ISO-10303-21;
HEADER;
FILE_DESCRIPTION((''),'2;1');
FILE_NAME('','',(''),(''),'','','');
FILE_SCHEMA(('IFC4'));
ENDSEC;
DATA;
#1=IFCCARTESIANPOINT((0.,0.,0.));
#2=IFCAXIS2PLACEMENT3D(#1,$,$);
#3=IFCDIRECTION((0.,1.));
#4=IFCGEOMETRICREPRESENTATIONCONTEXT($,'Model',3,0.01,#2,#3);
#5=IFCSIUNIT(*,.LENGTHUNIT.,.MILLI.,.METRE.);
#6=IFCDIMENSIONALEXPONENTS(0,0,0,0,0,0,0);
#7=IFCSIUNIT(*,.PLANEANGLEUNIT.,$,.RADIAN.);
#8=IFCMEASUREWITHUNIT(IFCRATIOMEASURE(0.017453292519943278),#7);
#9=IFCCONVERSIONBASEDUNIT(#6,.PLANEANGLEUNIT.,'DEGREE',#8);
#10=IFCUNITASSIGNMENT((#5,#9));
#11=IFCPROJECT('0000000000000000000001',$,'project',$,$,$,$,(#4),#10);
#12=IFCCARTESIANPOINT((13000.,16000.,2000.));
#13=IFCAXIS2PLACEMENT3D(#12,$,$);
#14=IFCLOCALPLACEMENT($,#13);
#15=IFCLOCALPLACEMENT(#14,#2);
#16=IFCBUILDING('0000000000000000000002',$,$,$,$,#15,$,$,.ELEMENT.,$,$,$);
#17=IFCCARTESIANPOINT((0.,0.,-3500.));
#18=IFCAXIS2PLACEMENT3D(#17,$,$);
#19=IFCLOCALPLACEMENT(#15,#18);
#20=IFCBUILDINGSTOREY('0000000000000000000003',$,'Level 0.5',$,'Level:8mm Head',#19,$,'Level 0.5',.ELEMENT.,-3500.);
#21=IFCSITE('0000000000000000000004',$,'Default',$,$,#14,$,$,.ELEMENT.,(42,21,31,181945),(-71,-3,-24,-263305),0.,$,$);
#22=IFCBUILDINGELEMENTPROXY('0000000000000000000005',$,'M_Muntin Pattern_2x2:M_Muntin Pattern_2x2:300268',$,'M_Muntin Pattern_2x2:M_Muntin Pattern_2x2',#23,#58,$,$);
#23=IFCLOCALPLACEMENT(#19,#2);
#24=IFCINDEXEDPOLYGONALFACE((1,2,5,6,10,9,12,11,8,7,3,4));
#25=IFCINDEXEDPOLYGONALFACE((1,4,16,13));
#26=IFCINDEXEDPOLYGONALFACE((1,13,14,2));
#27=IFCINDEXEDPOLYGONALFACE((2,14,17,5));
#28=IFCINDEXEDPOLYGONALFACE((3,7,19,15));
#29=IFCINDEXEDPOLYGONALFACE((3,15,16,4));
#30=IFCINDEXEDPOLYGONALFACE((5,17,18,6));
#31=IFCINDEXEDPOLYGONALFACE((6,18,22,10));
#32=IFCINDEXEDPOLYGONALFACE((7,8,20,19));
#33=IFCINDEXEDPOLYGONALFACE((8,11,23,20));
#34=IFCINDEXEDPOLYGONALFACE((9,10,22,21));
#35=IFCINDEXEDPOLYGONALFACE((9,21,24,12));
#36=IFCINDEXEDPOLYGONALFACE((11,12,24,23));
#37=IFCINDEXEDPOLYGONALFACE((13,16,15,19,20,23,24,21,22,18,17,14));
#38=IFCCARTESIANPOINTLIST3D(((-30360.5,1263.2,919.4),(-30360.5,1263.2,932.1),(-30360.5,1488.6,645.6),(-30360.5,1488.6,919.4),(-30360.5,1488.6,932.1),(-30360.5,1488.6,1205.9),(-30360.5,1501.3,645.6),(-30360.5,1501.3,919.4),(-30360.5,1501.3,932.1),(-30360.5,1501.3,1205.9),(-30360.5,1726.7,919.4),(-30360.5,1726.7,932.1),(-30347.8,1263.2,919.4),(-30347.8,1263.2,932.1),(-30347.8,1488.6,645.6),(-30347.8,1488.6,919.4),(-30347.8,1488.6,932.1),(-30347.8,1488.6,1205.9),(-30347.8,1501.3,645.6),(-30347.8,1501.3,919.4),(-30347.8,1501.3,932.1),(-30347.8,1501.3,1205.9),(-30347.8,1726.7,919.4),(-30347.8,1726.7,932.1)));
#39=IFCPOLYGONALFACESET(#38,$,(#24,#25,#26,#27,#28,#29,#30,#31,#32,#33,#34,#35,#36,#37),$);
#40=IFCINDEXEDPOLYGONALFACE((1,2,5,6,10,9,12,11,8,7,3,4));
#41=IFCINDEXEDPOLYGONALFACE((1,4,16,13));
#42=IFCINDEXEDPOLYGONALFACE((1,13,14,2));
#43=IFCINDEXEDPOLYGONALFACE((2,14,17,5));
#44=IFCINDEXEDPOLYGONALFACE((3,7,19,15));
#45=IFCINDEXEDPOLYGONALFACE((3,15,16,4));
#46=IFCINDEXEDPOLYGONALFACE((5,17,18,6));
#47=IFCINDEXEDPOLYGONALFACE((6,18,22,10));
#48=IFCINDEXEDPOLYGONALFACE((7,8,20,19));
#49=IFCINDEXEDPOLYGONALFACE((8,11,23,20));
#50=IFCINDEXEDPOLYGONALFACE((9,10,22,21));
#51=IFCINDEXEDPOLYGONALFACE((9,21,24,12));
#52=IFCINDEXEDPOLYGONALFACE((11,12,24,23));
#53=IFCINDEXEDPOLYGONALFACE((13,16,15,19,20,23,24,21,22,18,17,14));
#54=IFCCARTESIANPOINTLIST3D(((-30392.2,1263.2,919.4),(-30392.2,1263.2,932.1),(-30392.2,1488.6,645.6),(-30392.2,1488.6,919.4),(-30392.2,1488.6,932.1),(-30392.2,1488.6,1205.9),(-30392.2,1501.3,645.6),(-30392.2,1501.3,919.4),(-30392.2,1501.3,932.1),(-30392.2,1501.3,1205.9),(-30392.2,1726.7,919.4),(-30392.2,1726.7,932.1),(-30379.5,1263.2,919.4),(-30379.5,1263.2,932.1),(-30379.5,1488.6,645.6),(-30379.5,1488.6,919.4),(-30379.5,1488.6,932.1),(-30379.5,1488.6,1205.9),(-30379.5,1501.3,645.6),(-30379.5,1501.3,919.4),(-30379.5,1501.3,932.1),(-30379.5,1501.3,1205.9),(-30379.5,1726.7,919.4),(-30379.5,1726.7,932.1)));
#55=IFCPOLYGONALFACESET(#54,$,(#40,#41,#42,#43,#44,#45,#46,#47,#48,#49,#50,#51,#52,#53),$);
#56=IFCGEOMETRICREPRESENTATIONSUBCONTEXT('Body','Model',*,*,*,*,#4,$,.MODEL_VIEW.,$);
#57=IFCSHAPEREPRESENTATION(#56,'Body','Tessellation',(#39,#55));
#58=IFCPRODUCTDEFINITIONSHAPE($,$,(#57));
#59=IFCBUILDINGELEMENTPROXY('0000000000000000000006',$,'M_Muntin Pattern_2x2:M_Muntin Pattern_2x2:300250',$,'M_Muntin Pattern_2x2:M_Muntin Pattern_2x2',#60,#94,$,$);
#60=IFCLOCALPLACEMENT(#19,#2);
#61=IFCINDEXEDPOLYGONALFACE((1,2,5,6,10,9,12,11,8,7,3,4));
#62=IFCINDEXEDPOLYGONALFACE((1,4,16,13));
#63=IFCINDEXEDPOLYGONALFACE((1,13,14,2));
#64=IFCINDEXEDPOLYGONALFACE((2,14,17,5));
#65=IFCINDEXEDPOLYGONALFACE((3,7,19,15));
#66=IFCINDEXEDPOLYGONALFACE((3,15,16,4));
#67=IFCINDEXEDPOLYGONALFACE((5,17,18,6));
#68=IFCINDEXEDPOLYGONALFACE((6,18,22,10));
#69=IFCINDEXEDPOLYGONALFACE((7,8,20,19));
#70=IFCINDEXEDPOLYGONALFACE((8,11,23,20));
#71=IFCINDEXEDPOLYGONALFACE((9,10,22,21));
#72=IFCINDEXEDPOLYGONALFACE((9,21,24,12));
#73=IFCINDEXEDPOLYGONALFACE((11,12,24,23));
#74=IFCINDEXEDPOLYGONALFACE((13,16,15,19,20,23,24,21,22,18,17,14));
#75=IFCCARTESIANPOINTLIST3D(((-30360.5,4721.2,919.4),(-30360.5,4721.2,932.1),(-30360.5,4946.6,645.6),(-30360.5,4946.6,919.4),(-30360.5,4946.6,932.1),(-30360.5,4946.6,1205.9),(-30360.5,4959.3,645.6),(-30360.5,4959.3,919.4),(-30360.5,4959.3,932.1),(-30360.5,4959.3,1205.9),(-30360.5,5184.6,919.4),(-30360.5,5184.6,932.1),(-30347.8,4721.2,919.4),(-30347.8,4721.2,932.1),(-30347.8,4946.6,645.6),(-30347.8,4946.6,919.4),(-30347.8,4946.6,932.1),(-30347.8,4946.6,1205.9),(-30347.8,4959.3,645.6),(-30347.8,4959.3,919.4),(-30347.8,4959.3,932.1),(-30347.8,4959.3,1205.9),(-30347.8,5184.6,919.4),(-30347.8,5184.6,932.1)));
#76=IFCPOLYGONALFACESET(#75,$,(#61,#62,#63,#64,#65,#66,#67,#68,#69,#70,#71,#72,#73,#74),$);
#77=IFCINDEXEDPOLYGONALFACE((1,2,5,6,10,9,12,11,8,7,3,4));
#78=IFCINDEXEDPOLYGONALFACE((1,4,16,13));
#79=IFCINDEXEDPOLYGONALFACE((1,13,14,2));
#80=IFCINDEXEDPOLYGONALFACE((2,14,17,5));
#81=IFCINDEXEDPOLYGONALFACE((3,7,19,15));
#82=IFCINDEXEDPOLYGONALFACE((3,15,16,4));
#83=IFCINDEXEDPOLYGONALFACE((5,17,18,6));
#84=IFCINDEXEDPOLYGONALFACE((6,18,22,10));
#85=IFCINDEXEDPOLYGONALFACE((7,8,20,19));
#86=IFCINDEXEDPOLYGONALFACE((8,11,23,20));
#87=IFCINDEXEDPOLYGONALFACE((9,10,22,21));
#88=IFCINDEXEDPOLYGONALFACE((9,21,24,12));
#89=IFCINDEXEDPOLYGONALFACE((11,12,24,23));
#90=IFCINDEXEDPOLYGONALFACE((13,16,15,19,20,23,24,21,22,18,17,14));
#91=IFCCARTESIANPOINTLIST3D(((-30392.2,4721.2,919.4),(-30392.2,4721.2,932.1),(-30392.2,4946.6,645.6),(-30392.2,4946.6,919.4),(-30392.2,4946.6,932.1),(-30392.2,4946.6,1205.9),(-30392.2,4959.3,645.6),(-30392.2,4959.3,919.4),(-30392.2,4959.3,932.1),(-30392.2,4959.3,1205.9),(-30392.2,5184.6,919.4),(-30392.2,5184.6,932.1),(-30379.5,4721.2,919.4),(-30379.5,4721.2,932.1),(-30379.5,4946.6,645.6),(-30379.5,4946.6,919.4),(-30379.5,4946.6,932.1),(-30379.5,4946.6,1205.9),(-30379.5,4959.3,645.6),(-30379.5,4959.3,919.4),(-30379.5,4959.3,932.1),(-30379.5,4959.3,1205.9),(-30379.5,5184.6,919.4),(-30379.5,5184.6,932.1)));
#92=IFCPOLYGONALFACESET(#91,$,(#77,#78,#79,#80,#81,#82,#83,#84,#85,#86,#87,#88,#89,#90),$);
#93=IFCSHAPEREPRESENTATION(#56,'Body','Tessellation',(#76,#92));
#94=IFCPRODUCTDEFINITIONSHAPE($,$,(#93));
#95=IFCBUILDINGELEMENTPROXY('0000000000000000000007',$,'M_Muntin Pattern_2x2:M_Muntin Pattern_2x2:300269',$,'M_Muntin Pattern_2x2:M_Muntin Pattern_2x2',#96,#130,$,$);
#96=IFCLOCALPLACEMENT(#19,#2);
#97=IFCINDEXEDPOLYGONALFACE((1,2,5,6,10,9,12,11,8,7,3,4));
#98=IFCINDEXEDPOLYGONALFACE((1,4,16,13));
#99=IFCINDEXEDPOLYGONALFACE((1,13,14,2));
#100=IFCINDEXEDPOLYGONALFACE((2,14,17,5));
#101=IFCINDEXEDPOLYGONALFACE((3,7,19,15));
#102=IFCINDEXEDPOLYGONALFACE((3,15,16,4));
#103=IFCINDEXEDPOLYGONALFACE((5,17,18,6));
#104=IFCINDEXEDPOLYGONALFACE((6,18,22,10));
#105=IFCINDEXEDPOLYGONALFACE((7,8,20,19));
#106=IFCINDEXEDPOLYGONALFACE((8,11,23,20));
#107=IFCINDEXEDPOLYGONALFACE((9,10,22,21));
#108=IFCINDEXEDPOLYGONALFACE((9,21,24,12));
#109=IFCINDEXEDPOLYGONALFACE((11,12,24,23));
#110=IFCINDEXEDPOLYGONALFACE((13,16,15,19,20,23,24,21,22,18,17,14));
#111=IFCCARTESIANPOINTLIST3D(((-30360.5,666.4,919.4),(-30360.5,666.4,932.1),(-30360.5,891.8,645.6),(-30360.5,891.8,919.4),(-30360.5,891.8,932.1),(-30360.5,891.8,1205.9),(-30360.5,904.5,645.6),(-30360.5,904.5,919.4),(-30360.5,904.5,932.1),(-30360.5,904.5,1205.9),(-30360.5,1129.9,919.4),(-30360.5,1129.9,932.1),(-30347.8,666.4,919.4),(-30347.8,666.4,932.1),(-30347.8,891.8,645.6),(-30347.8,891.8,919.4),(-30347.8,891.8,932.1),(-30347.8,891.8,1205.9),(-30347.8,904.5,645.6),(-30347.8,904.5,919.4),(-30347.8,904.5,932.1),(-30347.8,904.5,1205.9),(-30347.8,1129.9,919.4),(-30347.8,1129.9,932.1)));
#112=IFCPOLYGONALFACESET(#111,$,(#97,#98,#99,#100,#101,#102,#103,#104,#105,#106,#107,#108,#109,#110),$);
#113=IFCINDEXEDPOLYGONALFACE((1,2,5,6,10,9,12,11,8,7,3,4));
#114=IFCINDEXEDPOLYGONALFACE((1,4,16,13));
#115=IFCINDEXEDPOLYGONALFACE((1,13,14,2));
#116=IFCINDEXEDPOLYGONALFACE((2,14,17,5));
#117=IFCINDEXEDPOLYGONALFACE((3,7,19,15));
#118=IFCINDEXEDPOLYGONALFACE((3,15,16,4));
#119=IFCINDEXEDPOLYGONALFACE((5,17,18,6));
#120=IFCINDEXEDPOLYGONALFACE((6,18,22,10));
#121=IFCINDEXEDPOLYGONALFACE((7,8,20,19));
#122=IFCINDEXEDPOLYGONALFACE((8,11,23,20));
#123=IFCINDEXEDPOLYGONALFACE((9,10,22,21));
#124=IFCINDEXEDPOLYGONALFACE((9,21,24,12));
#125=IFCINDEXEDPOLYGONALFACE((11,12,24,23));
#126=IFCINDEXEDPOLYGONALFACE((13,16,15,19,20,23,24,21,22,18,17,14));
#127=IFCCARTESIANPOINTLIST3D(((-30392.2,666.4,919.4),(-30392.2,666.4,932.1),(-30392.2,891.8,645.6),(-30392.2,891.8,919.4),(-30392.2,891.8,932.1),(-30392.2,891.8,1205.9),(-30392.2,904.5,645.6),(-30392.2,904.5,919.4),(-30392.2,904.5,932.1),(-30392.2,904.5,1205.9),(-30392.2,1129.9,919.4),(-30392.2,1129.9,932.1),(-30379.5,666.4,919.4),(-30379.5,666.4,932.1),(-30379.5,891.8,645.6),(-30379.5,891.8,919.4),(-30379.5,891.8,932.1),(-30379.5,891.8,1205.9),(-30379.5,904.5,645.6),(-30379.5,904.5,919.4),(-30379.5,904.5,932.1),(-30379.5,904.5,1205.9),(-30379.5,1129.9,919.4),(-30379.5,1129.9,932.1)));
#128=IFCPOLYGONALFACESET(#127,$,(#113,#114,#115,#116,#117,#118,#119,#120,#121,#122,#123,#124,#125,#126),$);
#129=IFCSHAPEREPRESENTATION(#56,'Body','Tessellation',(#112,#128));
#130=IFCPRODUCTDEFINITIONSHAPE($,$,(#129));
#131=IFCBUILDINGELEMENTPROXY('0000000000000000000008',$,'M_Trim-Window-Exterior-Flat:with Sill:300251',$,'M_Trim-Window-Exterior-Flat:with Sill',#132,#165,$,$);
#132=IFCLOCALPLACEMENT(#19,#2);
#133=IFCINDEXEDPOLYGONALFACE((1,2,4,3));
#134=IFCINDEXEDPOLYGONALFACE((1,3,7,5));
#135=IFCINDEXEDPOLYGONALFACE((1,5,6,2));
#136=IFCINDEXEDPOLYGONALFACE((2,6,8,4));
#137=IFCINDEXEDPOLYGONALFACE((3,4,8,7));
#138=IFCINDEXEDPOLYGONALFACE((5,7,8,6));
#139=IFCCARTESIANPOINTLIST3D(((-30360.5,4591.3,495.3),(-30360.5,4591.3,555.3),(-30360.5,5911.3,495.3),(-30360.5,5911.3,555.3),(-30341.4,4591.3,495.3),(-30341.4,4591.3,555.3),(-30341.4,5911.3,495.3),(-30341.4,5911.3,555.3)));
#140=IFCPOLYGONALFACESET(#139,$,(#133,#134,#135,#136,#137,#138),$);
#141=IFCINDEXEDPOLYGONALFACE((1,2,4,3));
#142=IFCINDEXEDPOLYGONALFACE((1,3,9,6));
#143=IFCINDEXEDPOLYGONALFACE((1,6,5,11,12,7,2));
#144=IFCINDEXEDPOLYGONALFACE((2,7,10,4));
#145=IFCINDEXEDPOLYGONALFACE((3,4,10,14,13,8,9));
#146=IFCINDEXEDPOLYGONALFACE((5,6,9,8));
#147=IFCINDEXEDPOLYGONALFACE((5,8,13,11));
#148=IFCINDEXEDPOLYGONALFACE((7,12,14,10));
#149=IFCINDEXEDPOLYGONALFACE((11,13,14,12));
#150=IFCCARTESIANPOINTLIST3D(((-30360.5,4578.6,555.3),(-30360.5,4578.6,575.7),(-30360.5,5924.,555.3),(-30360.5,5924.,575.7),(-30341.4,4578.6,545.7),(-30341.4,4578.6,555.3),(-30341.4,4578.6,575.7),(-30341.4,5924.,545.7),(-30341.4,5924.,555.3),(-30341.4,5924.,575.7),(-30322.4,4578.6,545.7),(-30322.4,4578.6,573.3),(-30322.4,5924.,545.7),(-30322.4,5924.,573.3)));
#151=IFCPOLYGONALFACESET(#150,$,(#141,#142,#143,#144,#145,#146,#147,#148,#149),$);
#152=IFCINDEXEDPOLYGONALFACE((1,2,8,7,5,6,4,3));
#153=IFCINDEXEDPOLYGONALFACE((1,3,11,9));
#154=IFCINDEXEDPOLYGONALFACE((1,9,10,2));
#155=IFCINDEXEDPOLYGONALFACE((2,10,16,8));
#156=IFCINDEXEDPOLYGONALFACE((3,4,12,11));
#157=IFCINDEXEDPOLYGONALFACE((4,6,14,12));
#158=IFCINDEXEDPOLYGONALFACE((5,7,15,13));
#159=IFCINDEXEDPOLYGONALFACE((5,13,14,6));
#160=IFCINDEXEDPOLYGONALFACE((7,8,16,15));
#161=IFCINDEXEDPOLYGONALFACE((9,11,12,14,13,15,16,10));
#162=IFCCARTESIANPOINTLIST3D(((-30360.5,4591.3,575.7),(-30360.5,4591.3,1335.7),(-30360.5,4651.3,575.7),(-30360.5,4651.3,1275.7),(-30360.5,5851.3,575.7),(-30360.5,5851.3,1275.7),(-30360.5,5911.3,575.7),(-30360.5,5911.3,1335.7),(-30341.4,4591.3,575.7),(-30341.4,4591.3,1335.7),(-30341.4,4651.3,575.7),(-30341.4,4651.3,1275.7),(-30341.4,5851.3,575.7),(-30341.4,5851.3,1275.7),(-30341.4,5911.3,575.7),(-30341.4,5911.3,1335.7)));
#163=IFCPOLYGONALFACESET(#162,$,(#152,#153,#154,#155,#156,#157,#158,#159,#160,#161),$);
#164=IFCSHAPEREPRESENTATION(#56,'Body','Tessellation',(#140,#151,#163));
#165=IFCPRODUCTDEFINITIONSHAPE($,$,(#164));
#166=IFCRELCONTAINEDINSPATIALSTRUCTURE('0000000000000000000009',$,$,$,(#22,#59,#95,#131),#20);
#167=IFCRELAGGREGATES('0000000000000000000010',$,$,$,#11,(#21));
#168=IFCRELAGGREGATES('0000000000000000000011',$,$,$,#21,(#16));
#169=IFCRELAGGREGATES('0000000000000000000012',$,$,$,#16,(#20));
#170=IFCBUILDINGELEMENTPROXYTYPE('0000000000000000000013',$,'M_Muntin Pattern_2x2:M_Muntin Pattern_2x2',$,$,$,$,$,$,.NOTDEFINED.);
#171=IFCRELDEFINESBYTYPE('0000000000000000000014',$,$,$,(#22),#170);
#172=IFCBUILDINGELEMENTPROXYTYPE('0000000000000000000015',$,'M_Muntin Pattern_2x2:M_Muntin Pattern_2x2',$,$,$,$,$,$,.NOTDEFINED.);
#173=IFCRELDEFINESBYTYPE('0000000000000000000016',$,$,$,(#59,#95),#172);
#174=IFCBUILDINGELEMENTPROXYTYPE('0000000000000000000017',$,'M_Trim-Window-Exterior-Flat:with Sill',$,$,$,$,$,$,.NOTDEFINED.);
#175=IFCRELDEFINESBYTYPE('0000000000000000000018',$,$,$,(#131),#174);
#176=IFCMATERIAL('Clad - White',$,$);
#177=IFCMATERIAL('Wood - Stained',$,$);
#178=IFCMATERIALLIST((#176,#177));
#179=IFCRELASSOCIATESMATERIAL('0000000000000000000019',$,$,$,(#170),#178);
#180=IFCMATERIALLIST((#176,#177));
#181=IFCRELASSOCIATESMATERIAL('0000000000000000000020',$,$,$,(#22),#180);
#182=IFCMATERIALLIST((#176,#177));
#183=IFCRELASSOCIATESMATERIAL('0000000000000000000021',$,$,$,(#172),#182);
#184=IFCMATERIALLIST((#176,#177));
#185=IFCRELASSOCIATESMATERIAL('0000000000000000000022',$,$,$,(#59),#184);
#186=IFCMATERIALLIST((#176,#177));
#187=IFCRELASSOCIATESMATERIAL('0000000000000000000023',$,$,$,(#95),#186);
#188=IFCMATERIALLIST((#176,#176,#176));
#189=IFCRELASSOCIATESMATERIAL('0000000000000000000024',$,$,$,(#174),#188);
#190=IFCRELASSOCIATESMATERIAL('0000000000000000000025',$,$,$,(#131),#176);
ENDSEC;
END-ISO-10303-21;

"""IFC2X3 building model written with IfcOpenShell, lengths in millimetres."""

from ifc_helpers import new_model, entity, si_unit, converted_unit, direction, frame, frame_2d, origin, place, context, subcontext, project, spatial, polyline, rectangle, outline, extrude, source, transform, mapped, material, material_list, type_object, type_shapes, element, save


model = new_model("IFC2X3")

# Units and contexts
model_context = context("Model", 3, precision=0.01, world=origin(), true_north=direction((0.0, 1.0)))
body_context = subcontext(model_context, "Body", "Model", "MODEL_VIEW")
ifc_project = project(units=[si_unit("LENGTHUNIT", "METRE", prefix="MILLI"), converted_unit("PLANEANGLEUNIT", "DEGREE", entity("IfcRatioMeasure", 0.017453292519943278), si_unit("PLANEANGLEUNIT", "RADIAN"), dimensions=[0, 0, 0, 0, 0, 0, 0])], contexts=[model_context])

# Site, building, storey
site_placement = place(None, frame((13000.0, 16000.0, 2000.0)))
site = spatial("IfcSite", under=ifc_project, at=site_placement, Name="Default", CompositionType="ELEMENT", RefLatitude=(42, 21, 31, 181945), RefLongitude=(-71, -3, -24, -263305), RefElevation=0.0)
building_placement = place(site_placement, origin())
building = spatial("IfcBuilding", under=site, at=building_placement, CompositionType="ELEMENT")
storey_placement = place(building_placement, frame((0.0, 0.0, -3500.0)))
storey = spatial("IfcBuildingStorey", under=building, at=storey_placement, Name="Level 0.5", ObjectType="Level:8mm Head", LongName="Level 0.5", CompositionType="ELEMENT", Elevation=-3500.0)

# Building element proxies
ifc_material_1 = material(Name="Clad - White")
ifc_material_2 = material(Name="Wood - Stained")
ifc_material_list_1 = material_list([ifc_material_1, ifc_material_2])
ifc_material_list_2 = material_list([ifc_material_1, ifc_material_2])
building_element_proxy_type_1 = type_object("IfcBuildingElementProxyType", Name="M_Muntin Pattern_2x2:M_Muntin Pattern_2x2", PredefinedType="NOTDEFINED", material=ifc_material_list_2)
shared_shape_1 = source(origin(), body_context, "Body", "SweptSolid", [
    extrude(outline(polyline([(6.4, -6.4), (280.1, -6.4), (280.1, 6.3), (6.4, 6.3), (6.4, 231.7), (-6.3, 231.7), (-6.3, 6.3), (-280.2, 6.3), (-280.2, -6.4), (-6.3, -6.4), (-6.3, -231.7), (6.4, -231.7), (6.4, -6.4)])), frame((0.0, 9.5, 280.1), z_axis=(0.0, 1.0, 0.0), x_axis=(0.0, 0.0, 1.0)), (0.0, 0.0, 1.0), 12.7),
    extrude(outline(polyline([(6.4, -6.4), (280.2, -6.4), (280.2, 6.3), (6.4, 6.3), (6.4, 231.7), (-6.3, 231.7), (-6.3, 6.3), (-280.2, 6.3), (-280.2, -6.4), (-6.3, -6.4), (-6.3, -231.7), (6.4, -231.7), (6.4, -6.4)])), frame((0.0, -22.2, 280.2), z_axis=(0.0, 1.0, 0.0), x_axis=(0.0, 0.0, 1.0)), (0.0, 0.0, 1.0), 12.7),
])
type_shapes(building_element_proxy_type_1, [shared_shape_1])
proxy_1_placement = place(storey_placement, frame((-30370.0, 1495.0, 645.6), z_axis=(0.0, 0.0, 1.0), x_axis=(0.0, -1.0, 0.0)))
element("IfcBuildingElementProxy", 1, at=proxy_1_placement, inside=storey, type_object=building_element_proxy_type_1, material=ifc_material_list_1, Name="M_Muntin Pattern_2x2:M_Muntin Pattern_2x2:300268", ObjectType="M_Muntin Pattern_2x2:M_Muntin Pattern_2x2", context=body_context, shape_type="MappedRepresentation", body=[
    mapped(shared_shape_1, transform((0.0, 0.0, 0.0), scale=1.0)),
])
ifc_material_list_3 = material_list([ifc_material_1, ifc_material_2])
ifc_material_list_4 = material_list([ifc_material_1, ifc_material_2])
building_element_proxy_type_2 = type_object("IfcBuildingElementProxyType", Name="M_Muntin Pattern_2x2:M_Muntin Pattern_2x2", PredefinedType="NOTDEFINED", material=ifc_material_list_4)
shared_shape_2 = source(origin(), body_context, "Body", "SweptSolid", [
    extrude(outline(polyline([(6.4, -6.4), (280.1, -6.4), (280.1, 6.3), (6.4, 6.3), (6.4, 231.7), (-6.3, 231.7), (-6.3, 6.3), (-280.2, 6.3), (-280.2, -6.4), (-6.3, -6.4), (-6.3, -231.7), (6.4, -231.7), (6.4, -6.4)])), frame((0.0, -22.2, 280.1), z_axis=(0.0, 1.0, 0.0), x_axis=(0.0, 0.0, 1.0)), (0.0, 0.0, 1.0), 12.7),
    extrude(outline(polyline([(6.4, -6.4), (280.2, -6.4), (280.2, 6.3), (6.4, 6.3), (6.4, 231.7), (-6.3, 231.7), (-6.3, 6.3), (-280.2, 6.3), (-280.2, -6.4), (-6.3, -6.4), (-6.3, -231.7), (6.4, -231.7), (6.4, -6.4)])), frame((0.0, 9.5, 280.2), z_axis=(0.0, 1.0, 0.0), x_axis=(0.0, 0.0, 1.0)), (0.0, 0.0, 1.0), 12.7),
])
type_shapes(building_element_proxy_type_2, [shared_shape_2])
proxy_2_placement = place(storey_placement, frame((-30370.0, 4952.9, 645.6), z_axis=(0.0, 0.0, 1.0), x_axis=(0.0, 1.0, 0.0)))
element("IfcBuildingElementProxy", 2, at=proxy_2_placement, inside=storey, type_object=building_element_proxy_type_2, material=ifc_material_list_3, Name="M_Muntin Pattern_2x2:M_Muntin Pattern_2x2:300250", ObjectType="M_Muntin Pattern_2x2:M_Muntin Pattern_2x2", context=body_context, shape_type="MappedRepresentation", body=[
    mapped(shared_shape_2, transform((0.0, 0.0, 0.0), scale=1.0)),
])
ifc_material_list_5 = material_list([ifc_material_1, ifc_material_2])
proxy_3_placement = place(storey_placement, frame((-30370.0, 898.1, 645.6), z_axis=(0.0, 0.0, 1.0), x_axis=(0.0, 1.0, 0.0)))
element("IfcBuildingElementProxy", 3, at=proxy_3_placement, inside=storey, type_object=building_element_proxy_type_2, material=ifc_material_list_5, Name="M_Muntin Pattern_2x2:M_Muntin Pattern_2x2:300269", ObjectType="M_Muntin Pattern_2x2:M_Muntin Pattern_2x2", context=body_context, shape_type="MappedRepresentation", body=[
    mapped(shared_shape_2, transform((0.0, 0.0, 0.0), scale=1.0)),
])
ifc_material_list_6 = material_list([ifc_material_1, ifc_material_1, ifc_material_1])
building_element_proxy_type_3 = type_object("IfcBuildingElementProxyType", Name="M_Trim-Window-Exterior-Flat:with Sill", PredefinedType="NOTDEFINED", material=ifc_material_list_6)
shared_shape_3 = source(origin(), body_context, "Body", "SweptSolid", [
    extrude(rectangle(XDim=1320.0, YDim=60.0, at=frame_2d((0.0, 0.0), x_axis=(1.0, 0.0))), frame((0.0, -750.4, 0.0), z_axis=(0.0, 0.0, 1.0), x_axis=(-1.0, 0.0, 0.0)), (0.0, 0.0, 1.0), 19.0),
    extrude(outline(polyline([(-19.0, -15.2), (0.0, -15.2), (0.0, -5.7), (19.0, -5.7), (19.0, 14.8), (0.0, 14.8), (-19.0, 12.3), (-19.0, -15.2)])), frame((-672.7, -714.8, 19.0), z_axis=(1.0, 0.0, 0.0), x_axis=(0.0, 0.0, -1.0)), (0.0, 0.0, 1.0), 1345.4),
    extrude(outline(polyline([(-395.0, -660.0), (365.0, -660.0), (365.0, -600.0), (-335.0, -600.0), (-335.0, 600.0), (365.0, 600.0), (365.0, 660.0), (-395.0, 660.0), (-395.0, -660.0)])), frame((0.0, -335.0, 0.0), z_axis=(0.0, 0.0, 1.0), x_axis=(0.0, -1.0, 0.0)), (0.0, 0.0, 1.0), 19.0),
])
type_shapes(building_element_proxy_type_3, [shared_shape_3])
for number, where, z_axis, x_axis, name in (
    (4, (-30360.5, 5251.3, 1275.7), (1.0, 0.0, 0.0), (0.0, 1.0, 0.0), "M_Trim-Window-Exterior-Flat:with Sill:300251"),
):
    element("IfcBuildingElementProxy", number, at=place(storey_placement, frame(where, z_axis=z_axis, x_axis=x_axis)), inside=storey, type_object=building_element_proxy_type_3, material=ifc_material_1, Name=name, ObjectType="M_Trim-Window-Exterior-Flat:with Sill", context=body_context, shape_type="MappedRepresentation", body=[
        mapped(shared_shape_3, transform((0.0, 0.0, 0.0), scale=1.0)),
    ])

save(model, "model.ifc")
